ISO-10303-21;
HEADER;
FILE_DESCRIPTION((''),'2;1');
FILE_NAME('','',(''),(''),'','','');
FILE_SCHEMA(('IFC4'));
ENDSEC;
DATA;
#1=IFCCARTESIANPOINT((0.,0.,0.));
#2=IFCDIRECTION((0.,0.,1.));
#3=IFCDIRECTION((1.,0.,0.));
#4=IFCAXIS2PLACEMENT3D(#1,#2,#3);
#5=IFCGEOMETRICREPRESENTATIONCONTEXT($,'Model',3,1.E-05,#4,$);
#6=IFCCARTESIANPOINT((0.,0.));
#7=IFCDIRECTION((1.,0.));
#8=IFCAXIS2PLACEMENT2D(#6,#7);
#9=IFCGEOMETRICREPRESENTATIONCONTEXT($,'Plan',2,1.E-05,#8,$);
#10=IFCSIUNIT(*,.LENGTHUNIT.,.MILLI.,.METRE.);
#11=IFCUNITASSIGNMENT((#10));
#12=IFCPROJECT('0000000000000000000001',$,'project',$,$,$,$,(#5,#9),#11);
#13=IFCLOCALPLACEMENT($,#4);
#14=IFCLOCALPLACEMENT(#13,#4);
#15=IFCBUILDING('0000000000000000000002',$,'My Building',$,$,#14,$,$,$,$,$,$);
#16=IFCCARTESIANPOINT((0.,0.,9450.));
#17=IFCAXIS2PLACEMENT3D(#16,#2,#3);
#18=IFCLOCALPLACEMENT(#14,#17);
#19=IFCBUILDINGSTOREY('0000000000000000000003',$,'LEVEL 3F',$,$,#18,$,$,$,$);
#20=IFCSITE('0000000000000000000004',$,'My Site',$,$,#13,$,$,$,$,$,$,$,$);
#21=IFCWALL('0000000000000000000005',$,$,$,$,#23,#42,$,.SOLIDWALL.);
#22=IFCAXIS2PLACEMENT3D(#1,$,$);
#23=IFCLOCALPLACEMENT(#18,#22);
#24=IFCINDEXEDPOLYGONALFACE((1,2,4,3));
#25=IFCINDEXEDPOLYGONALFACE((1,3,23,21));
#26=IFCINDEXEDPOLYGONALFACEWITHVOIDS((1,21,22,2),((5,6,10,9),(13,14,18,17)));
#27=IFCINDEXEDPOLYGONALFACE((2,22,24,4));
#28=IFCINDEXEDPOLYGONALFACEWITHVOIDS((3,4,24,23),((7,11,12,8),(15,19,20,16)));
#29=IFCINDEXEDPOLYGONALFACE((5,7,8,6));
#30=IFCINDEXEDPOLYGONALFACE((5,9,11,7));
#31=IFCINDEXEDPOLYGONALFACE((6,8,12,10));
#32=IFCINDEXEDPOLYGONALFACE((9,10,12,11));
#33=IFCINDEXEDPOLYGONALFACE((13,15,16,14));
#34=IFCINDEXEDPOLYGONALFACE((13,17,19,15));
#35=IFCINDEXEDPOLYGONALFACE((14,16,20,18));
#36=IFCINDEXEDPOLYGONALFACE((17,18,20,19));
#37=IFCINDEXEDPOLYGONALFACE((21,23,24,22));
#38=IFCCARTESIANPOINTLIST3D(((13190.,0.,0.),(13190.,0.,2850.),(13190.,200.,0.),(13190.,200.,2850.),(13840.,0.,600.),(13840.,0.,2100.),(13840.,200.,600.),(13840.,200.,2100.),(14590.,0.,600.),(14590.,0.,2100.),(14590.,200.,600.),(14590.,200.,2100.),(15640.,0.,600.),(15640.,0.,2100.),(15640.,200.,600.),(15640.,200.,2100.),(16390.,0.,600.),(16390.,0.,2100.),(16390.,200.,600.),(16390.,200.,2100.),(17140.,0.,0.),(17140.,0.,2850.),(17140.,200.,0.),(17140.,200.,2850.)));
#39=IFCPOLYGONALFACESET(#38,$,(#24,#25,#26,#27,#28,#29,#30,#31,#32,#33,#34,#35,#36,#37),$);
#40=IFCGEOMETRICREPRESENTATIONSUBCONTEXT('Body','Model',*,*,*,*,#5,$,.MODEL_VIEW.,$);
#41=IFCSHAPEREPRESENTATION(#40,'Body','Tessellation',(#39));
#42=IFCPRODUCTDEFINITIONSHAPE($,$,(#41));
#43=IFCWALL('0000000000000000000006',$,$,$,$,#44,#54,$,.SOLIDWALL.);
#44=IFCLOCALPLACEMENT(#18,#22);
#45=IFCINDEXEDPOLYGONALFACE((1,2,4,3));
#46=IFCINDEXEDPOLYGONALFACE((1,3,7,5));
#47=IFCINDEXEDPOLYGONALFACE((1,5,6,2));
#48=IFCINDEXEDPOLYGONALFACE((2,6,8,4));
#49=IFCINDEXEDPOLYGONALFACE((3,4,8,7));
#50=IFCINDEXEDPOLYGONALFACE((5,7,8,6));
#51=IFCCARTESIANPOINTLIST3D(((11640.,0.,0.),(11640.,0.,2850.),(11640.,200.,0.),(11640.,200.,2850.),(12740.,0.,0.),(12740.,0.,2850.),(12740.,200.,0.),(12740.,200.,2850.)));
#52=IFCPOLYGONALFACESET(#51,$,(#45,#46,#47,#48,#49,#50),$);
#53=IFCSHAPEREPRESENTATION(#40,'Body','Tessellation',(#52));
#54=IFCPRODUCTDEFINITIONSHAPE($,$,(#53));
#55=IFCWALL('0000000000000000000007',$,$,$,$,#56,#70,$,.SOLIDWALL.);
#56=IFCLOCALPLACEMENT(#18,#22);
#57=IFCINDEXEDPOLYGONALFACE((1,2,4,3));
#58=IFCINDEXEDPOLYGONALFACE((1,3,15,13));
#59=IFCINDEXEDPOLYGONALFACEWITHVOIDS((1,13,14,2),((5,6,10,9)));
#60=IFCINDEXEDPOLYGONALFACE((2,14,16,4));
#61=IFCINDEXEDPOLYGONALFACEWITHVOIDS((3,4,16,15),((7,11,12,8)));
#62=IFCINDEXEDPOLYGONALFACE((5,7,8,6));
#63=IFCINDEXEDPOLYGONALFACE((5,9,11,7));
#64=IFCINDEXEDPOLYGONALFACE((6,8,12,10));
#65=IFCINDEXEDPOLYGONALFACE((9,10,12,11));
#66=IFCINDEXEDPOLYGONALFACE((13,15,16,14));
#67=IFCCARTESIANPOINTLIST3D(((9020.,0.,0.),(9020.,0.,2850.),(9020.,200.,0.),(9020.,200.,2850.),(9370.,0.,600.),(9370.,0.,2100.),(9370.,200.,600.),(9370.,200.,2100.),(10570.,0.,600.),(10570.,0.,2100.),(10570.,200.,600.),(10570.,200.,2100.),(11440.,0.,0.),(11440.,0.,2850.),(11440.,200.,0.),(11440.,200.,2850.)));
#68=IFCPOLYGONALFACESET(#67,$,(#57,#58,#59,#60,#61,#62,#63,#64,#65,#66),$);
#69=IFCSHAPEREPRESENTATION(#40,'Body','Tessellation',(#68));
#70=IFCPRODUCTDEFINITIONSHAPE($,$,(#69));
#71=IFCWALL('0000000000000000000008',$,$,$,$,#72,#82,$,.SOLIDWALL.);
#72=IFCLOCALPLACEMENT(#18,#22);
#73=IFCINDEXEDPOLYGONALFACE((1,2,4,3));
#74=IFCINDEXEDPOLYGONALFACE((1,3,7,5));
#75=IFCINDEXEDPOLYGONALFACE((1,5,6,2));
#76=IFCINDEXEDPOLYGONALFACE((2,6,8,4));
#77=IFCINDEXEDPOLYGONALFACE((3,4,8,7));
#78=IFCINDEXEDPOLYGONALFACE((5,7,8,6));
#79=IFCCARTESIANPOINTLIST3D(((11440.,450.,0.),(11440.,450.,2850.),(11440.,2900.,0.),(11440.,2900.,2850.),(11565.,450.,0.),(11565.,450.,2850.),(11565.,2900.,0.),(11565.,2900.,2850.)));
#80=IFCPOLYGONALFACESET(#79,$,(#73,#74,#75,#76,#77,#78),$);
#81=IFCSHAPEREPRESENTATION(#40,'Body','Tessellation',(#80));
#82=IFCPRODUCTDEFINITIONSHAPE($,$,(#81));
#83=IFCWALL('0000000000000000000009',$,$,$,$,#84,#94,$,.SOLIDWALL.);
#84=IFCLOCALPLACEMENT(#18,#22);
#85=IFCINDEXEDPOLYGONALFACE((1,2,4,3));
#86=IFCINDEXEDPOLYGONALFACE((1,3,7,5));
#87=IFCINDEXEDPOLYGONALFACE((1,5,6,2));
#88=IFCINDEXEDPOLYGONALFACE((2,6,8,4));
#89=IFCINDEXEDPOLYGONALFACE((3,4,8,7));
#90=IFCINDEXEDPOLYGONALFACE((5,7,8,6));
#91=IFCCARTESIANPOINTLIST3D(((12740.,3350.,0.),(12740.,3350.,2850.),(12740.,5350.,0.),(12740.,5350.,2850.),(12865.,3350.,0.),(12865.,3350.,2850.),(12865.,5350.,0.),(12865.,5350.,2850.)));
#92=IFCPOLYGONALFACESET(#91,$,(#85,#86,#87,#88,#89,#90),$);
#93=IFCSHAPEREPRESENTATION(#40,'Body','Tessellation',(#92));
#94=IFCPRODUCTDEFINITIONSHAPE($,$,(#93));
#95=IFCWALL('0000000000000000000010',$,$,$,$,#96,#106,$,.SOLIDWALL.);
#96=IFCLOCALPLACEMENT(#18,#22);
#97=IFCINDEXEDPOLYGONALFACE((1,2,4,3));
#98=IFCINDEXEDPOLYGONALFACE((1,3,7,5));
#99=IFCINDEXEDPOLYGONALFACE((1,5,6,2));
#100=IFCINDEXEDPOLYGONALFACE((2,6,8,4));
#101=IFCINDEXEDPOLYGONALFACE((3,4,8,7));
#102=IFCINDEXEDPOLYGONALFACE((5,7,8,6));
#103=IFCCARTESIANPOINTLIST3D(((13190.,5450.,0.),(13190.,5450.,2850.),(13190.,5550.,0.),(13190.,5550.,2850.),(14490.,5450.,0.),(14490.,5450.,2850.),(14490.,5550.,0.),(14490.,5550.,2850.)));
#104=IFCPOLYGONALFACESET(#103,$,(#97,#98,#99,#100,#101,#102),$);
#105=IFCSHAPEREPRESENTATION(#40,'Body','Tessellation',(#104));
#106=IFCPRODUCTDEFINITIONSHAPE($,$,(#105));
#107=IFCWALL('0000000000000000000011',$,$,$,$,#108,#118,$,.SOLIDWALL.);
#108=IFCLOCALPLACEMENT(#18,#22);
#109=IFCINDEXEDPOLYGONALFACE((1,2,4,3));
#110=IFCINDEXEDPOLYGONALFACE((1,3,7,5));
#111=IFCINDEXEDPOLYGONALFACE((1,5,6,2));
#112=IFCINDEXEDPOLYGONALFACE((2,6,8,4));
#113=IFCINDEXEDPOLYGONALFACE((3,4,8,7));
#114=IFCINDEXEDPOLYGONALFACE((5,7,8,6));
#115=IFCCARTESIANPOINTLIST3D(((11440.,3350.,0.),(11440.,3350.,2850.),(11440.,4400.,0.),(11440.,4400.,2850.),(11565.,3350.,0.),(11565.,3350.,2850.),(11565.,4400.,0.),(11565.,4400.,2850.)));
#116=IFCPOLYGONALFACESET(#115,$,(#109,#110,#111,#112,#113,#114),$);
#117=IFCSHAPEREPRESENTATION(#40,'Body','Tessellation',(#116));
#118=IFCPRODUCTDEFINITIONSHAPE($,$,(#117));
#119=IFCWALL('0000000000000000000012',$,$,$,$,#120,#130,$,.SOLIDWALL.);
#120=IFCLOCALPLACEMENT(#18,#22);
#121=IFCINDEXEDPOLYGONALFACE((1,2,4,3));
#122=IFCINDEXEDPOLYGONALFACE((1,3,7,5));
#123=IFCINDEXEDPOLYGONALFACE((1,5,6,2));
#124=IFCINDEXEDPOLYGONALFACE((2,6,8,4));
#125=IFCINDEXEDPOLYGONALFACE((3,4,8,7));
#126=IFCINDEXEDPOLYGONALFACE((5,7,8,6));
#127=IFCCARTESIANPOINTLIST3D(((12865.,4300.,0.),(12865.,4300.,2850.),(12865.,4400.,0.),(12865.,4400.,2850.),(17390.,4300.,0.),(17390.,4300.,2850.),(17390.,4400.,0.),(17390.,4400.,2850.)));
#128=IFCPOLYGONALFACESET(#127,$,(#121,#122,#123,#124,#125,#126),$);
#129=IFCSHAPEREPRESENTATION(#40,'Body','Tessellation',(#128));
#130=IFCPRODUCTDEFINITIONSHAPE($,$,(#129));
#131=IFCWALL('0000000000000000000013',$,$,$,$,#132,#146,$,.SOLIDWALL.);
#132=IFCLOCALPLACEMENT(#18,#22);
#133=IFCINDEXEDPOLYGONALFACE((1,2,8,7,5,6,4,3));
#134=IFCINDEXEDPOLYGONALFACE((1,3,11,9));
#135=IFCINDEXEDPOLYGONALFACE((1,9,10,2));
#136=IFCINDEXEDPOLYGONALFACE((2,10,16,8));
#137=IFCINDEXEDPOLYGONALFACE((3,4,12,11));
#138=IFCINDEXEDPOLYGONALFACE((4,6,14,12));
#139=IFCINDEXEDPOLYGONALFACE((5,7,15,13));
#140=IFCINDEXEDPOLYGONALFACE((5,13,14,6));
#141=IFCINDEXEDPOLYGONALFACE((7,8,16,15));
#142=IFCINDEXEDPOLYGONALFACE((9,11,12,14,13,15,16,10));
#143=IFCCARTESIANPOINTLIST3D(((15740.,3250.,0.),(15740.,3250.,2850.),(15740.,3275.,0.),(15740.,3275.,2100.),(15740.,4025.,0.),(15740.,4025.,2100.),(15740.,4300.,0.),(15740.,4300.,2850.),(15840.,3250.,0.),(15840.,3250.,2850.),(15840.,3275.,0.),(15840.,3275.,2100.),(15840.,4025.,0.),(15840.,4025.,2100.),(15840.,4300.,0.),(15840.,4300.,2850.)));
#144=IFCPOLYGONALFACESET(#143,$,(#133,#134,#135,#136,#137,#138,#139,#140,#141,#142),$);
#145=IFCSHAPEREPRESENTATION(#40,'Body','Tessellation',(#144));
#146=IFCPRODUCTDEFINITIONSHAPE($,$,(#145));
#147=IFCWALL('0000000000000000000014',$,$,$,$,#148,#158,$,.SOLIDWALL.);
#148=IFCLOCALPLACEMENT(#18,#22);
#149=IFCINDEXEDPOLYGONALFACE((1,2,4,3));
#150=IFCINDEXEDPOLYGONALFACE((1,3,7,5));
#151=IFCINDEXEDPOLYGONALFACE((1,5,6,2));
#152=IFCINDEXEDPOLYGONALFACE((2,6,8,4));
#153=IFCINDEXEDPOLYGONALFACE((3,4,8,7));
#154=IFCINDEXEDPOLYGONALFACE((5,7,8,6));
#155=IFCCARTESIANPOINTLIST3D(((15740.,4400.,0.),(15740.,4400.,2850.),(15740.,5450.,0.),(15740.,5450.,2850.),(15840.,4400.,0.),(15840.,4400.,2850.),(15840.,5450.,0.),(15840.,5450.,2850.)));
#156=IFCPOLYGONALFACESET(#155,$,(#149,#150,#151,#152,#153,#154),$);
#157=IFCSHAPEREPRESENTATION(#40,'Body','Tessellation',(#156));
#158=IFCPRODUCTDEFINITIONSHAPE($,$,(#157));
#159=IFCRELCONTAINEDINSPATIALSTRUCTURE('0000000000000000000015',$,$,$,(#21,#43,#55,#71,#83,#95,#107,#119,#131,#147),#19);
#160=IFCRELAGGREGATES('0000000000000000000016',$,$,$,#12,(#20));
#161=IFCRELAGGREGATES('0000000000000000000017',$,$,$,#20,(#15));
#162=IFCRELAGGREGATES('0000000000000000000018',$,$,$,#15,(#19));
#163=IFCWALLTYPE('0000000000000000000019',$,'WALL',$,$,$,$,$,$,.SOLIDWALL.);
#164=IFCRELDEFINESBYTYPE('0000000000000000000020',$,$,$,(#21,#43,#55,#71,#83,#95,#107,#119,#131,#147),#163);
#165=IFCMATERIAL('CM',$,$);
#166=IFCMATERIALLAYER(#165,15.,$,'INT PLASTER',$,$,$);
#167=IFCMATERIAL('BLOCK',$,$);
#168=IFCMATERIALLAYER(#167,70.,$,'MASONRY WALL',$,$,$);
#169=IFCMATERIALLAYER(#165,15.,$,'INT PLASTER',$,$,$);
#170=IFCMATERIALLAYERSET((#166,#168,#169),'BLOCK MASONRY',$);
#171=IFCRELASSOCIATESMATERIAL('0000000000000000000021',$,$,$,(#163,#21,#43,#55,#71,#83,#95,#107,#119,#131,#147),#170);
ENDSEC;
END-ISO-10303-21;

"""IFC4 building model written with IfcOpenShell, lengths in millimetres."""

from ifc_helpers import new_model, si_unit, frame, origin_with_axes, origin_2d_with_axis, place, context, subcontext, project, spatial, indexed_curve, outline, extrude, material, layer, layer_set, layer_usage, type_object, element, save


model = new_model("IFC4")

# Units and contexts
model_context = context("Model", 3, precision=1e-05, world=origin_with_axes())
plan_context = context("Plan", 2, precision=1e-05, world=origin_2d_with_axis())
body_context = subcontext(model_context, "Body", "Model", "MODEL_VIEW")
ifc_project = project(units=[si_unit("LENGTHUNIT", "METRE", prefix="MILLI")], contexts=[model_context, plan_context])

# Site, building, storey
site_placement = place(None, origin_with_axes())
site = spatial("IfcSite", under=ifc_project, at=site_placement, Name="My Site")
building_placement = place(site_placement, origin_with_axes())
building = spatial("IfcBuilding", under=site, at=building_placement, Name="My Building")
storey_placement = place(building_placement, frame((0.0, 0.0, 9450.0), z_axis=(0.0, 0.0, 1.0), x_axis=(1.0, 0.0, 0.0)))
storey = spatial("IfcBuildingStorey", under=building, at=storey_placement, Name="LEVEL 3F")

# Shared definitions
ifc_material_1 = material(Name="CM")
ifc_layer_1 = layer(ifc_material_1, 15.0, Name="INT PLASTER")
ifc_material_2 = material(Name="BLOCK")
ifc_layer_2 = layer(ifc_material_2, 70.0, Name="MASONRY WALL")
ifc_layer_3 = layer(ifc_material_1, 15.0, Name="INT PLASTER")
ifc_layer_set = layer_set([ifc_layer_1, ifc_layer_2, ifc_layer_3], Name="BLOCK MASONRY")
wall_type = type_object("IfcWallType", Name="WALL", PredefinedType="SOLIDWALL", material=ifc_layer_set)

# Wall, openings
ifc_layer_usage_1 = layer_usage(ifc_layer_set, "AXIS2", "POSITIVE", 0.0)
wall_1_placement = place(storey_placement, frame((13190.0, 200.0, 0.0), z_axis=(0.0, 0.0, 1.0), x_axis=(0.0, -1.0, 0.0)))
wall_1 = element("IfcWall", 1, at=wall_1_placement, inside=storey, type_object=wall_type, material=ifc_layer_usage_1, PredefinedType="SOLIDWALL", context=body_context, shape_type="SweptSolid", body=[
    extrude(outline(indexed_curve([(0.0, 0.0), (0.0, 3950.0), (200.0, 3950.0), (200.0, 0.0), (0.0, 0.0)], self_intersect=False)), origin_with_axes(), (0.0, 0.0, 1.0), 2850.0),
])
opening_1_placement = place(wall_1_placement, frame((0.0, 3200.0, 600.0), z_axis=(0.0, 0.0, 1.0), x_axis=(0.0, -1.0, 0.0)))
element("IfcOpeningElement", 2, at=opening_1_placement, cuts=wall_1, PredefinedType="OPENING", context=body_context, shape_type="SweptSolid", body=[
    extrude(outline(indexed_curve([(0.0, 0.0), (0.0, 400.0), (750.0, 400.0), (750.0, 0.0), (0.0, 0.0)], self_intersect=False)), frame((0.0, -100.0, 0.0), z_axis=(0.0, 0.0, 1.0), x_axis=(1.0, 0.0, 0.0)), (0.0, 0.0, 1.0), 1500.0),
])
opening_2_placement = place(wall_1_placement, frame((0.0, 1400.0, 600.0), z_axis=(0.0, 0.0, 1.0), x_axis=(0.0, -1.0, 0.0)))
element("IfcOpeningElement", 3, at=opening_2_placement, cuts=wall_1, PredefinedType="OPENING", context=body_context, shape_type="SweptSolid", body=[
    extrude(outline(indexed_curve([(0.0, 0.0), (0.0, 400.0), (750.0, 400.0), (750.0, 0.0), (0.0, 0.0)], self_intersect=False)), frame((0.0, -100.0, 0.0), z_axis=(0.0, 0.0, 1.0), x_axis=(1.0, 0.0, 0.0)), (0.0, 0.0, 1.0), 1500.0),
])

# Wall
ifc_layer_usage_2 = layer_usage(ifc_layer_set, "AXIS2", "POSITIVE", 0.0)
wall_2_placement = place(storey_placement, frame((11640.0, 200.0, 0.0), z_axis=(0.0, 0.0, 1.0), x_axis=(0.0, -1.0, 0.0)))
element("IfcWall", 4, at=wall_2_placement, inside=storey, type_object=wall_type, material=ifc_layer_usage_2, PredefinedType="SOLIDWALL", context=body_context, shape_type="SweptSolid", body=[
    extrude(outline(indexed_curve([(0.0, 0.0), (0.0, 1100.0), (200.0, 1100.0), (200.0, 0.0), (0.0, 0.0)], self_intersect=False)), origin_with_axes(), (0.0, 0.0, 1.0), 2850.0),
])

# Wall, opening
ifc_layer_usage_3 = layer_usage(ifc_layer_set, "AXIS2", "POSITIVE", 0.0)
wall_3_placement = place(storey_placement, frame((9020.0, 200.0, 0.0), z_axis=(0.0, 0.0, 1.0), x_axis=(0.0, -1.0, 0.0)))
wall_3 = element("IfcWall", 5, at=wall_3_placement, inside=storey, type_object=wall_type, material=ifc_layer_usage_3, PredefinedType="SOLIDWALL", context=body_context, shape_type="SweptSolid", body=[
    extrude(outline(indexed_curve([(0.0, 0.0), (0.0, 2420.0), (200.0, 2420.0), (200.0, 0.0), (0.0, 0.0)], self_intersect=False)), origin_with_axes(), (0.0, 0.0, 1.0), 2850.0),
])
opening_3_placement = place(wall_3_placement, frame((0.0, 1550.0, 600.0), z_axis=(0.0, 0.0, 1.0), x_axis=(0.0, -1.0, 0.0)))
element("IfcOpeningElement", 6, at=opening_3_placement, cuts=wall_3, PredefinedType="OPENING", context=body_context, shape_type="SweptSolid", body=[
    extrude(outline(indexed_curve([(0.0, 0.0), (0.0, 400.0), (1200.0, 400.0), (1200.0, 0.0), (0.0, 0.0)], self_intersect=False)), frame((0.0, -100.0, 0.0), z_axis=(0.0, 0.0, 1.0), x_axis=(1.0, 0.0, 0.0)), (0.0, 0.0, 1.0), 1500.0),
])

# Wall
ifc_layer_usage_4 = layer_usage(ifc_layer_set, "AXIS2", "POSITIVE", 0.0)
wall_4_placement = place(storey_placement, frame((11565.0, 450.0, 0.0), z_axis=(0.0, 0.0, 1.0), x_axis=(0.0, 1.0, 0.0)))
element("IfcWall", 7, at=wall_4_placement, inside=storey, type_object=wall_type, material=ifc_layer_usage_4, PredefinedType="SOLIDWALL", context=body_context, shape_type="SweptSolid", body=[
    extrude(outline(indexed_curve([(0.0, 0.0), (0.0, 125.0), (2450.0, 125.0), (2450.0, 0.0), (0.0, 0.0)], self_intersect=False)), origin_with_axes(), (0.0, 0.0, 1.0), 2850.0),
])

# Walls
ifc_layer_usage_5 = layer_usage(ifc_layer_set, "AXIS2", "POSITIVE", 0.0)
wall_5_placement = place(storey_placement, frame((12865.0, 3350.0, 0.0), z_axis=(0.0, 0.0, 1.0), x_axis=(0.0, 1.0, 0.0)))
element("IfcWall", 8, at=wall_5_placement, inside=storey, type_object=wall_type, material=ifc_layer_usage_5, PredefinedType="SOLIDWALL", context=body_context, shape_type="SweptSolid", body=[
    extrude(outline(indexed_curve([(0.0, 0.0), (0.0, 125.0), (2000.0, 125.0), (2000.0, 0.0), (0.0, 0.0)], self_intersect=False)), origin_with_axes(), (0.0, 0.0, 1.0), 2850.0),
])
ifc_layer_usage_6 = layer_usage(ifc_layer_set, "AXIS2", "POSITIVE", 0.0)
wall_6_placement = place(storey_placement, frame((13190.0, 5550.0, 0.0), z_axis=(0.0, 0.0, 1.0), x_axis=(0.0, -1.0, 0.0)))
element("IfcWall", 9, at=wall_6_placement, inside=storey, type_object=wall_type, material=ifc_layer_usage_6, PredefinedType="SOLIDWALL", context=body_context, shape_type="SweptSolid", body=[
    extrude(outline(indexed_curve([(0.0, 0.0), (0.0, 1300.0), (100.0, 1300.0), (100.0, 0.0), (0.0, 0.0)], self_intersect=False)), origin_with_axes(), (0.0, 0.0, 1.0), 2850.0),
])
ifc_layer_usage_7 = layer_usage(ifc_layer_set, "AXIS2", "POSITIVE", 0.0)
wall_7_placement = place(storey_placement, frame((11565.0, 3350.0, 0.0), z_axis=(0.0, 0.0, 1.0), x_axis=(0.0, 1.0, 0.0)))
element("IfcWall", 10, at=wall_7_placement, inside=storey, type_object=wall_type, material=ifc_layer_usage_7, PredefinedType="SOLIDWALL", context=body_context, shape_type="SweptSolid", body=[
    extrude(outline(indexed_curve([(0.0, 0.0), (0.0, 125.0), (1050.0, 125.0), (1050.0, 0.0), (0.0, 0.0)], self_intersect=False)), origin_with_axes(), (0.0, 0.0, 1.0), 2850.0),
])
ifc_layer_usage_8 = layer_usage(ifc_layer_set, "AXIS2", "POSITIVE", 0.0)
wall_8_placement = place(storey_placement, frame((12865.0, 4400.0, 0.0), z_axis=(0.0, 0.0, 1.0), x_axis=(0.0, -1.0, 0.0)))
element("IfcWall", 11, at=wall_8_placement, inside=storey, type_object=wall_type, material=ifc_layer_usage_8, PredefinedType="SOLIDWALL", context=body_context, shape_type="SweptSolid", body=[
    extrude(outline(indexed_curve([(0.0, 0.0), (0.0, 4525.0), (100.0, 4525.0), (100.0, 0.0), (0.0, 0.0)], self_intersect=False)), origin_with_axes(), (0.0, 0.0, 1.0), 2850.0),
])

# Wall, opening
ifc_layer_usage_9 = layer_usage(ifc_layer_set, "AXIS2", "POSITIVE", 0.0)
wall_9_placement = place(storey_placement, frame((15840.0, 3250.0, 0.0), z_axis=(0.0, 0.0, 1.0), x_axis=(0.0, 1.0, 0.0)))
wall_9 = element("IfcWall", 12, at=wall_9_placement, inside=storey, type_object=wall_type, material=ifc_layer_usage_9, PredefinedType="SOLIDWALL", context=body_context, shape_type="SweptSolid", body=[
    extrude(outline(indexed_curve([(0.0, 0.0), (0.0, 100.0), (1050.0, 100.0), (1050.0, 0.0), (0.0, 0.0)], self_intersect=False)), origin_with_axes(), (0.0, 0.0, 1.0), 2850.0),
])
opening_4_placement = place(wall_9_placement, frame((775.0, 100.0, 0.0), z_axis=(0.0, 0.0, 1.0), x_axis=(-1.0, 0.0, 0.0)))
element("IfcOpeningElement", 13, at=opening_4_placement, cuts=wall_9, PredefinedType="OPENING", context=body_context, shape_type="SweptSolid", body=[
    extrude(outline(indexed_curve([(0.0, 0.0), (0.0, 400.0), (750.0, 400.0), (750.0, 0.0), (0.0, 0.0)], self_intersect=False)), frame((0.0, -100.0, 0.0), z_axis=(0.0, 0.0, 1.0), x_axis=(1.0, 0.0, 0.0)), (0.0, 0.0, 1.0), 2100.0),
])

# Wall
ifc_layer_usage_10 = layer_usage(ifc_layer_set, "AXIS2", "POSITIVE", 0.0)
wall_10_placement = place(storey_placement, frame((15840.0, 4400.0, 0.0), z_axis=(0.0, 0.0, 1.0), x_axis=(0.0, 1.0, 0.0)))
element("IfcWall", 14, at=wall_10_placement, inside=storey, type_object=wall_type, material=ifc_layer_usage_10, PredefinedType="SOLIDWALL", context=body_context, shape_type="SweptSolid", body=[
    extrude(outline(indexed_curve([(0.0, 0.0), (0.0, 100.0), (1050.0, 100.0), (1050.0, 0.0), (0.0, 0.0)], self_intersect=False)), origin_with_axes(), (0.0, 0.0, 1.0), 2850.0),
])

save(model, "model.ifc")
